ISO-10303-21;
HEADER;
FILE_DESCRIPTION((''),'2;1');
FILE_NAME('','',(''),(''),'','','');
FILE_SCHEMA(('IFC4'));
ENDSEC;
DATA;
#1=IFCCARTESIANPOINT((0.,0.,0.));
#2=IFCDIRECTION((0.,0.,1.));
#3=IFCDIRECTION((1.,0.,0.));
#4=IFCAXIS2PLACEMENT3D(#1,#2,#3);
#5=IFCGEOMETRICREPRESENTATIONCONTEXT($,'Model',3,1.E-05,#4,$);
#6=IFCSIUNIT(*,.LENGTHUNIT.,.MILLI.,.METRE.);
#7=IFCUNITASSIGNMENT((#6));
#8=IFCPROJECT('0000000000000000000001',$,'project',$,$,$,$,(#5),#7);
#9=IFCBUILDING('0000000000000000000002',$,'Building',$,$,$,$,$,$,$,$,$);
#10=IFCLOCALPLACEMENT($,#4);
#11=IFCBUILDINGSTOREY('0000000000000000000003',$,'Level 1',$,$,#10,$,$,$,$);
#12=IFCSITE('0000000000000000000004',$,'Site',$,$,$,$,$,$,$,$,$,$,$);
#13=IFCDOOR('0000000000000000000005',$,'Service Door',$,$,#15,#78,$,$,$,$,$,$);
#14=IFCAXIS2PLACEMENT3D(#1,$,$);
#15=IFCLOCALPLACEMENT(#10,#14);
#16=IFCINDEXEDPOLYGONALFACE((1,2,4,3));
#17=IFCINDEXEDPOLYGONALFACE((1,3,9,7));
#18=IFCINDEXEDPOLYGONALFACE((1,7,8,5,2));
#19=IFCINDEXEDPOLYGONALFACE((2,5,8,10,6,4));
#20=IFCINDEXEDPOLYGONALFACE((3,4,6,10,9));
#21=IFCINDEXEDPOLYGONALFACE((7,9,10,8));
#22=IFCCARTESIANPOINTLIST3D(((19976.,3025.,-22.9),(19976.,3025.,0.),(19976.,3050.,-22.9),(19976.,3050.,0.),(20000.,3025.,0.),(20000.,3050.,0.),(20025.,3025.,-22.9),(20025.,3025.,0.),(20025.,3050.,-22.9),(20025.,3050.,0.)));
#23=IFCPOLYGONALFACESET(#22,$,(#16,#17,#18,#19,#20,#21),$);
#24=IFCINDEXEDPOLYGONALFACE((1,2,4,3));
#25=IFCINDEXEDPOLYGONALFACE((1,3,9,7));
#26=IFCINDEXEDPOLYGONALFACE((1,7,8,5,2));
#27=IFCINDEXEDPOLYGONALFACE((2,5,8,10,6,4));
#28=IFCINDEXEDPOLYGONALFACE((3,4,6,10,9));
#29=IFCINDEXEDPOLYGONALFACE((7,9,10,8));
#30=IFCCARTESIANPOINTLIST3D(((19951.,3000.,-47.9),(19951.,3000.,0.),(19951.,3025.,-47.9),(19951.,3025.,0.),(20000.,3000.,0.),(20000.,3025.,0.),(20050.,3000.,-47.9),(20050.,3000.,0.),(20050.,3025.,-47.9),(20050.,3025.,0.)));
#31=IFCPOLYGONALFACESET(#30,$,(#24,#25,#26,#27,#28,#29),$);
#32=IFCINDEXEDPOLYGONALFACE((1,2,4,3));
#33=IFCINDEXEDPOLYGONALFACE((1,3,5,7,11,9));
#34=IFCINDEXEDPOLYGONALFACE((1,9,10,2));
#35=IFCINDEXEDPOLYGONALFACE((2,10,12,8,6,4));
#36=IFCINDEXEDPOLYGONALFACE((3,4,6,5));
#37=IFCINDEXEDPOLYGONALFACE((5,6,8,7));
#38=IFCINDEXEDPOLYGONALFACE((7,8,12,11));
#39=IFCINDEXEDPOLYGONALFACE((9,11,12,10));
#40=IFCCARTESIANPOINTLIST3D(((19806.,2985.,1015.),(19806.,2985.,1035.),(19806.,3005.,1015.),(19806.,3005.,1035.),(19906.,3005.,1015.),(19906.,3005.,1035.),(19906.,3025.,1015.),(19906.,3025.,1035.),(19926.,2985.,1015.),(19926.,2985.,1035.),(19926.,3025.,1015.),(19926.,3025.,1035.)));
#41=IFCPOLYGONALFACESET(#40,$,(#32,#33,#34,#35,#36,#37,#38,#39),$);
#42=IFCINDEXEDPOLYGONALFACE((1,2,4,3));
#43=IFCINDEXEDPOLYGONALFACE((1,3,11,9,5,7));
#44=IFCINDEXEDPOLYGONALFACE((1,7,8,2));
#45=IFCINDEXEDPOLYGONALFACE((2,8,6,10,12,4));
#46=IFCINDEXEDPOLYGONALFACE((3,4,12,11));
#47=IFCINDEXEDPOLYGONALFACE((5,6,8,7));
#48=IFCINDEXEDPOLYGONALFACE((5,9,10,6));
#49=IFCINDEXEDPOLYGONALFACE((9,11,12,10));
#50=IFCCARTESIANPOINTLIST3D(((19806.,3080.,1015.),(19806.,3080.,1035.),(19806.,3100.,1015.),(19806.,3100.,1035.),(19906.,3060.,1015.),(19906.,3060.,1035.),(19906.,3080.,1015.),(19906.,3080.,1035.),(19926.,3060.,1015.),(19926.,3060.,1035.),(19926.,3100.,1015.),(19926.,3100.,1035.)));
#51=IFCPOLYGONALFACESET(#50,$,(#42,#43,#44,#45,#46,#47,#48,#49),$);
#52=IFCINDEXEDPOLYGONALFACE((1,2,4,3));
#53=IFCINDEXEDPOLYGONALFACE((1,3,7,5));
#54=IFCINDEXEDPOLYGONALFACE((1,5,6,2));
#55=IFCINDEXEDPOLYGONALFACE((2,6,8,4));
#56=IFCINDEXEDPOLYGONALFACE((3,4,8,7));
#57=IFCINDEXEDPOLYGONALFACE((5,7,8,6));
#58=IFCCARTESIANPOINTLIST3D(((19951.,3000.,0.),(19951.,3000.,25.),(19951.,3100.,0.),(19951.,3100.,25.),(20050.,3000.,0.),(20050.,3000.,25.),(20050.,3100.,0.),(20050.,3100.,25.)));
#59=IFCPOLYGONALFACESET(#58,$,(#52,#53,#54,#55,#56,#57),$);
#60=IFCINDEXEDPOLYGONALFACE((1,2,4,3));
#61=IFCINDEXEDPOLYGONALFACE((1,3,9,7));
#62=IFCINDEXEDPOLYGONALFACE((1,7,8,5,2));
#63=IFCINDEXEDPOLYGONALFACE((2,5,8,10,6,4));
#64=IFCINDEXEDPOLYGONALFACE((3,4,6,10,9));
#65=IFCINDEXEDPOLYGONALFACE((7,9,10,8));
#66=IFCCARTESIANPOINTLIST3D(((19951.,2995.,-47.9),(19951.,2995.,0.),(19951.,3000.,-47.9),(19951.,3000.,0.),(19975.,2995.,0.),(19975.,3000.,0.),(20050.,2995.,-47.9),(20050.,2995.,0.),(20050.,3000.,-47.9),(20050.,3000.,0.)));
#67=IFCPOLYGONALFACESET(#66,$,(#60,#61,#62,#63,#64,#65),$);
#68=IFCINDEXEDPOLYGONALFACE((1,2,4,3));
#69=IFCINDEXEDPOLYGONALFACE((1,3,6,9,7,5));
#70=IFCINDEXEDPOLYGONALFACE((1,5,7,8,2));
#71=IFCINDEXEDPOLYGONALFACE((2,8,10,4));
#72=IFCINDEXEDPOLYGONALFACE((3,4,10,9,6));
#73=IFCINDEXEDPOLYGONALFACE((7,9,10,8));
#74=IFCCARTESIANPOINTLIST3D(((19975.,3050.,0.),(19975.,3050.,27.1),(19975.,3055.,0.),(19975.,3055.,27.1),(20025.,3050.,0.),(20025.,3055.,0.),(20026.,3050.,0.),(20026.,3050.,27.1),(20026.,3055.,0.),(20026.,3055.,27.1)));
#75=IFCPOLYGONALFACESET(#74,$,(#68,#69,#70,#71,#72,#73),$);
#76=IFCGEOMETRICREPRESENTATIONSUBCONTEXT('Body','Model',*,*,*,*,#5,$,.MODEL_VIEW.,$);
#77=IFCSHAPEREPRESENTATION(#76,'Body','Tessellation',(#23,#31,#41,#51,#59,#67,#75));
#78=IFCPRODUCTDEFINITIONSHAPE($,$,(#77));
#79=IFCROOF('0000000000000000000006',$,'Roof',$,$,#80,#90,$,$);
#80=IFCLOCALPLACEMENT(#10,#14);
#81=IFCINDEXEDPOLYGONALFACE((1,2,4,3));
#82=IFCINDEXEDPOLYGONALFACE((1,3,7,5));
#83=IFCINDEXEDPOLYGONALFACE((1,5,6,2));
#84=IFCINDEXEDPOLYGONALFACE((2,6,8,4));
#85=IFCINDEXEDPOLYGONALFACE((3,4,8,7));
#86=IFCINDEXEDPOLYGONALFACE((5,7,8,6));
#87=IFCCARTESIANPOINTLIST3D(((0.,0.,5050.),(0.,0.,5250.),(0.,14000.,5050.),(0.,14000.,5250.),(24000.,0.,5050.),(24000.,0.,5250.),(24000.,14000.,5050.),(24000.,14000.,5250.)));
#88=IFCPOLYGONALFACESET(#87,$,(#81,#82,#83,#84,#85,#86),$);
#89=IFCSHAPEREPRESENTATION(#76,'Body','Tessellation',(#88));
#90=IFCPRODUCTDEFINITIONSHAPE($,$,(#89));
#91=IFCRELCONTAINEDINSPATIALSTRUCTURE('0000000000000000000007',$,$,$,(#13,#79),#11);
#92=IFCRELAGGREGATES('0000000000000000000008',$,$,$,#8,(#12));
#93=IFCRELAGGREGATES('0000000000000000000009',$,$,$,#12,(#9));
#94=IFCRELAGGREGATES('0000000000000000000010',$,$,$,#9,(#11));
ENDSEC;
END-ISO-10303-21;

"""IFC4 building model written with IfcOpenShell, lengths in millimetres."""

from ifc_helpers import new_model, si_unit, frame, origin_with_axes, place, context, subcontext, project, spatial, line, indexed_curve, outline, extrude, element, save


model = new_model("IFC4")

# Units and contexts
model_context = context("Model", 3, precision=1e-05, world=origin_with_axes())
body_context = subcontext(model_context, "Body", "Model", "MODEL_VIEW")
ifc_project = project(units=[si_unit("LENGTHUNIT", "METRE", prefix="MILLI")], contexts=[model_context])

# Site, building, storey
site = spatial("IfcSite", under=ifc_project, Name="Site")
building = spatial("IfcBuilding", under=site, Name="Building")
storey_placement = place(None, origin_with_axes())
storey = spatial("IfcBuildingStorey", under=building, at=storey_placement, Name="Level 1")

# Door
door_1_placement = place(storey_placement, frame((20000.0, 3000.0, 0.0), z_axis=(0.0, 0.0, 1.0), x_axis=(1.0, 0.0, 0.0)))
element("IfcDoor", 1, at=door_1_placement, inside=storey, Name="Service Door", context=body_context, shape_type="SweptSolid", body=[
    extrude(outline(indexed_curve([(0.0, 0.0), (0.0, 2.1), (1.0, 2.1), (1.0, 0.0), (-24.0, 0.0), (-24.0, -22.9), (25.0, -22.9), (25.0, 0.0)], segments=[line(1, 2, 3, 4, 5, 6, 7, 8, 1)])), frame((0.0, 25.0, 0.0), z_axis=(0.0, -1.0, 0.0), x_axis=(1.0, 0.0, 0.0)), (0.0, 0.0, -1.0), 25.0),
    extrude(outline(indexed_curve([(0.0, 0.0), (0.0, 2.1), (1.0, 2.1), (1.0, 0.0), (-49.0, 0.0), (-49.0, -47.9), (50.0, -47.9), (50.0, 0.0)], segments=[line(1, 2, 3, 4, 5, 6, 7, 8, 1)])), frame((0.0, 0.0, 0.0), z_axis=(0.0, -1.0, 0.0), x_axis=(1.0, 0.0, 0.0)), (0.0, 0.0, -1.0), 25.0),
    extrude(outline(indexed_curve([(0.0, 0.0), (-49.0, 0.0), (-49.0, 35.0), (0.0, 35.0)], segments=[line(1, 2, 3, 4, 1)])), frame((25.0, 25.0, 25.0), z_axis=(0.0, 0.0, 1.0), x_axis=(1.0, 0.0, 0.0)), (0.0, 0.0, 1.0), -47.9),
    extrude(outline(indexed_curve([(0.0, 0.0), (0.0, -40.0), (-120.0, -40.0), (-120.0, -20.0), (-20.0, -20.0), (-20.0, 0.0)], segments=[line(1, 2, 3, 4, 5, 6, 1)])), frame((-74.0, 25.0, 1015.0), z_axis=(0.0, 0.0, 1.0), x_axis=(1.0, 0.0, 0.0)), (0.0, 0.0, 1.0), 20.0),
    extrude(outline(indexed_curve([(0.0, 0.0), (0.0, 40.0), (-120.0, 40.0), (-120.0, 20.0), (-20.0, 20.0), (-20.0, 0.0)], segments=[line(1, 2, 3, 4, 5, 6, 1)])), frame((-74.0, 60.0, 1015.0), z_axis=(0.0, 0.0, 1.0), x_axis=(1.0, 0.0, 0.0)), (0.0, 0.0, 1.0), 20.0),
    extrude(outline(indexed_curve([(0.0, 0.0), (-99.0, 0.0), (-99.0, 100.0), (0.0, 100.0)], segments=[line(1, 2, 3, 4, 1)])), frame((50.0, 0.0, 0.0), z_axis=(0.0, 0.0, 1.0), x_axis=(1.0, 0.0, 0.0)), (0.0, 0.0, 1.0), 25.0),
    extrude(outline(indexed_curve([(0.0, 0.0), (0.0, 27.1), (51.0, 27.1), (51.0, 0.0), (-24.0, 0.0), (-24.0, -47.9), (75.0, -47.9), (75.0, 0.0)], segments=[line(1, 2, 3, 4, 5, 6, 7, 8, 1)])), frame((-25.0, -5.0, 0.0), z_axis=(0.0, -1.0, 0.0), x_axis=(1.0, 0.0, 0.0)), (0.0, 0.0, -1.0), 5.0),
    extrude(outline(indexed_curve([(0.0, 0.0), (0.0, 27.1), (51.0, 27.1), (51.0, 0.0), (1.0, 0.0), (1.0, -22.9), (50.0, -22.9), (50.0, 0.0)], segments=[line(1, 2, 3, 4, 5, 6, 7, 8, 1)])), frame((-25.0, 50.0, 0.0), z_axis=(0.0, -1.0, 0.0), x_axis=(1.0, 0.0, 0.0)), (0.0, 0.0, -1.0), 5.0),
])

# Roof
roof_placement = place(storey_placement, frame((0.0, 0.0, 5050.0), z_axis=(0.0, 0.0, 1.0), x_axis=(1.0, 0.0, 0.0)))
element("IfcRoof", 2, at=roof_placement, inside=storey, Name="Roof", context=body_context, shape_type="SweptSolid", body=[
    extrude(outline(indexed_curve([(0.0, 0.0), (24000.0, 0.0), (24000.0, 14000.0), (0.0, 14000.0), (0.0, 0.0)])), None, (0.0, 0.0, 1.0), 200.0),
])

save(model, "model.ifc")
